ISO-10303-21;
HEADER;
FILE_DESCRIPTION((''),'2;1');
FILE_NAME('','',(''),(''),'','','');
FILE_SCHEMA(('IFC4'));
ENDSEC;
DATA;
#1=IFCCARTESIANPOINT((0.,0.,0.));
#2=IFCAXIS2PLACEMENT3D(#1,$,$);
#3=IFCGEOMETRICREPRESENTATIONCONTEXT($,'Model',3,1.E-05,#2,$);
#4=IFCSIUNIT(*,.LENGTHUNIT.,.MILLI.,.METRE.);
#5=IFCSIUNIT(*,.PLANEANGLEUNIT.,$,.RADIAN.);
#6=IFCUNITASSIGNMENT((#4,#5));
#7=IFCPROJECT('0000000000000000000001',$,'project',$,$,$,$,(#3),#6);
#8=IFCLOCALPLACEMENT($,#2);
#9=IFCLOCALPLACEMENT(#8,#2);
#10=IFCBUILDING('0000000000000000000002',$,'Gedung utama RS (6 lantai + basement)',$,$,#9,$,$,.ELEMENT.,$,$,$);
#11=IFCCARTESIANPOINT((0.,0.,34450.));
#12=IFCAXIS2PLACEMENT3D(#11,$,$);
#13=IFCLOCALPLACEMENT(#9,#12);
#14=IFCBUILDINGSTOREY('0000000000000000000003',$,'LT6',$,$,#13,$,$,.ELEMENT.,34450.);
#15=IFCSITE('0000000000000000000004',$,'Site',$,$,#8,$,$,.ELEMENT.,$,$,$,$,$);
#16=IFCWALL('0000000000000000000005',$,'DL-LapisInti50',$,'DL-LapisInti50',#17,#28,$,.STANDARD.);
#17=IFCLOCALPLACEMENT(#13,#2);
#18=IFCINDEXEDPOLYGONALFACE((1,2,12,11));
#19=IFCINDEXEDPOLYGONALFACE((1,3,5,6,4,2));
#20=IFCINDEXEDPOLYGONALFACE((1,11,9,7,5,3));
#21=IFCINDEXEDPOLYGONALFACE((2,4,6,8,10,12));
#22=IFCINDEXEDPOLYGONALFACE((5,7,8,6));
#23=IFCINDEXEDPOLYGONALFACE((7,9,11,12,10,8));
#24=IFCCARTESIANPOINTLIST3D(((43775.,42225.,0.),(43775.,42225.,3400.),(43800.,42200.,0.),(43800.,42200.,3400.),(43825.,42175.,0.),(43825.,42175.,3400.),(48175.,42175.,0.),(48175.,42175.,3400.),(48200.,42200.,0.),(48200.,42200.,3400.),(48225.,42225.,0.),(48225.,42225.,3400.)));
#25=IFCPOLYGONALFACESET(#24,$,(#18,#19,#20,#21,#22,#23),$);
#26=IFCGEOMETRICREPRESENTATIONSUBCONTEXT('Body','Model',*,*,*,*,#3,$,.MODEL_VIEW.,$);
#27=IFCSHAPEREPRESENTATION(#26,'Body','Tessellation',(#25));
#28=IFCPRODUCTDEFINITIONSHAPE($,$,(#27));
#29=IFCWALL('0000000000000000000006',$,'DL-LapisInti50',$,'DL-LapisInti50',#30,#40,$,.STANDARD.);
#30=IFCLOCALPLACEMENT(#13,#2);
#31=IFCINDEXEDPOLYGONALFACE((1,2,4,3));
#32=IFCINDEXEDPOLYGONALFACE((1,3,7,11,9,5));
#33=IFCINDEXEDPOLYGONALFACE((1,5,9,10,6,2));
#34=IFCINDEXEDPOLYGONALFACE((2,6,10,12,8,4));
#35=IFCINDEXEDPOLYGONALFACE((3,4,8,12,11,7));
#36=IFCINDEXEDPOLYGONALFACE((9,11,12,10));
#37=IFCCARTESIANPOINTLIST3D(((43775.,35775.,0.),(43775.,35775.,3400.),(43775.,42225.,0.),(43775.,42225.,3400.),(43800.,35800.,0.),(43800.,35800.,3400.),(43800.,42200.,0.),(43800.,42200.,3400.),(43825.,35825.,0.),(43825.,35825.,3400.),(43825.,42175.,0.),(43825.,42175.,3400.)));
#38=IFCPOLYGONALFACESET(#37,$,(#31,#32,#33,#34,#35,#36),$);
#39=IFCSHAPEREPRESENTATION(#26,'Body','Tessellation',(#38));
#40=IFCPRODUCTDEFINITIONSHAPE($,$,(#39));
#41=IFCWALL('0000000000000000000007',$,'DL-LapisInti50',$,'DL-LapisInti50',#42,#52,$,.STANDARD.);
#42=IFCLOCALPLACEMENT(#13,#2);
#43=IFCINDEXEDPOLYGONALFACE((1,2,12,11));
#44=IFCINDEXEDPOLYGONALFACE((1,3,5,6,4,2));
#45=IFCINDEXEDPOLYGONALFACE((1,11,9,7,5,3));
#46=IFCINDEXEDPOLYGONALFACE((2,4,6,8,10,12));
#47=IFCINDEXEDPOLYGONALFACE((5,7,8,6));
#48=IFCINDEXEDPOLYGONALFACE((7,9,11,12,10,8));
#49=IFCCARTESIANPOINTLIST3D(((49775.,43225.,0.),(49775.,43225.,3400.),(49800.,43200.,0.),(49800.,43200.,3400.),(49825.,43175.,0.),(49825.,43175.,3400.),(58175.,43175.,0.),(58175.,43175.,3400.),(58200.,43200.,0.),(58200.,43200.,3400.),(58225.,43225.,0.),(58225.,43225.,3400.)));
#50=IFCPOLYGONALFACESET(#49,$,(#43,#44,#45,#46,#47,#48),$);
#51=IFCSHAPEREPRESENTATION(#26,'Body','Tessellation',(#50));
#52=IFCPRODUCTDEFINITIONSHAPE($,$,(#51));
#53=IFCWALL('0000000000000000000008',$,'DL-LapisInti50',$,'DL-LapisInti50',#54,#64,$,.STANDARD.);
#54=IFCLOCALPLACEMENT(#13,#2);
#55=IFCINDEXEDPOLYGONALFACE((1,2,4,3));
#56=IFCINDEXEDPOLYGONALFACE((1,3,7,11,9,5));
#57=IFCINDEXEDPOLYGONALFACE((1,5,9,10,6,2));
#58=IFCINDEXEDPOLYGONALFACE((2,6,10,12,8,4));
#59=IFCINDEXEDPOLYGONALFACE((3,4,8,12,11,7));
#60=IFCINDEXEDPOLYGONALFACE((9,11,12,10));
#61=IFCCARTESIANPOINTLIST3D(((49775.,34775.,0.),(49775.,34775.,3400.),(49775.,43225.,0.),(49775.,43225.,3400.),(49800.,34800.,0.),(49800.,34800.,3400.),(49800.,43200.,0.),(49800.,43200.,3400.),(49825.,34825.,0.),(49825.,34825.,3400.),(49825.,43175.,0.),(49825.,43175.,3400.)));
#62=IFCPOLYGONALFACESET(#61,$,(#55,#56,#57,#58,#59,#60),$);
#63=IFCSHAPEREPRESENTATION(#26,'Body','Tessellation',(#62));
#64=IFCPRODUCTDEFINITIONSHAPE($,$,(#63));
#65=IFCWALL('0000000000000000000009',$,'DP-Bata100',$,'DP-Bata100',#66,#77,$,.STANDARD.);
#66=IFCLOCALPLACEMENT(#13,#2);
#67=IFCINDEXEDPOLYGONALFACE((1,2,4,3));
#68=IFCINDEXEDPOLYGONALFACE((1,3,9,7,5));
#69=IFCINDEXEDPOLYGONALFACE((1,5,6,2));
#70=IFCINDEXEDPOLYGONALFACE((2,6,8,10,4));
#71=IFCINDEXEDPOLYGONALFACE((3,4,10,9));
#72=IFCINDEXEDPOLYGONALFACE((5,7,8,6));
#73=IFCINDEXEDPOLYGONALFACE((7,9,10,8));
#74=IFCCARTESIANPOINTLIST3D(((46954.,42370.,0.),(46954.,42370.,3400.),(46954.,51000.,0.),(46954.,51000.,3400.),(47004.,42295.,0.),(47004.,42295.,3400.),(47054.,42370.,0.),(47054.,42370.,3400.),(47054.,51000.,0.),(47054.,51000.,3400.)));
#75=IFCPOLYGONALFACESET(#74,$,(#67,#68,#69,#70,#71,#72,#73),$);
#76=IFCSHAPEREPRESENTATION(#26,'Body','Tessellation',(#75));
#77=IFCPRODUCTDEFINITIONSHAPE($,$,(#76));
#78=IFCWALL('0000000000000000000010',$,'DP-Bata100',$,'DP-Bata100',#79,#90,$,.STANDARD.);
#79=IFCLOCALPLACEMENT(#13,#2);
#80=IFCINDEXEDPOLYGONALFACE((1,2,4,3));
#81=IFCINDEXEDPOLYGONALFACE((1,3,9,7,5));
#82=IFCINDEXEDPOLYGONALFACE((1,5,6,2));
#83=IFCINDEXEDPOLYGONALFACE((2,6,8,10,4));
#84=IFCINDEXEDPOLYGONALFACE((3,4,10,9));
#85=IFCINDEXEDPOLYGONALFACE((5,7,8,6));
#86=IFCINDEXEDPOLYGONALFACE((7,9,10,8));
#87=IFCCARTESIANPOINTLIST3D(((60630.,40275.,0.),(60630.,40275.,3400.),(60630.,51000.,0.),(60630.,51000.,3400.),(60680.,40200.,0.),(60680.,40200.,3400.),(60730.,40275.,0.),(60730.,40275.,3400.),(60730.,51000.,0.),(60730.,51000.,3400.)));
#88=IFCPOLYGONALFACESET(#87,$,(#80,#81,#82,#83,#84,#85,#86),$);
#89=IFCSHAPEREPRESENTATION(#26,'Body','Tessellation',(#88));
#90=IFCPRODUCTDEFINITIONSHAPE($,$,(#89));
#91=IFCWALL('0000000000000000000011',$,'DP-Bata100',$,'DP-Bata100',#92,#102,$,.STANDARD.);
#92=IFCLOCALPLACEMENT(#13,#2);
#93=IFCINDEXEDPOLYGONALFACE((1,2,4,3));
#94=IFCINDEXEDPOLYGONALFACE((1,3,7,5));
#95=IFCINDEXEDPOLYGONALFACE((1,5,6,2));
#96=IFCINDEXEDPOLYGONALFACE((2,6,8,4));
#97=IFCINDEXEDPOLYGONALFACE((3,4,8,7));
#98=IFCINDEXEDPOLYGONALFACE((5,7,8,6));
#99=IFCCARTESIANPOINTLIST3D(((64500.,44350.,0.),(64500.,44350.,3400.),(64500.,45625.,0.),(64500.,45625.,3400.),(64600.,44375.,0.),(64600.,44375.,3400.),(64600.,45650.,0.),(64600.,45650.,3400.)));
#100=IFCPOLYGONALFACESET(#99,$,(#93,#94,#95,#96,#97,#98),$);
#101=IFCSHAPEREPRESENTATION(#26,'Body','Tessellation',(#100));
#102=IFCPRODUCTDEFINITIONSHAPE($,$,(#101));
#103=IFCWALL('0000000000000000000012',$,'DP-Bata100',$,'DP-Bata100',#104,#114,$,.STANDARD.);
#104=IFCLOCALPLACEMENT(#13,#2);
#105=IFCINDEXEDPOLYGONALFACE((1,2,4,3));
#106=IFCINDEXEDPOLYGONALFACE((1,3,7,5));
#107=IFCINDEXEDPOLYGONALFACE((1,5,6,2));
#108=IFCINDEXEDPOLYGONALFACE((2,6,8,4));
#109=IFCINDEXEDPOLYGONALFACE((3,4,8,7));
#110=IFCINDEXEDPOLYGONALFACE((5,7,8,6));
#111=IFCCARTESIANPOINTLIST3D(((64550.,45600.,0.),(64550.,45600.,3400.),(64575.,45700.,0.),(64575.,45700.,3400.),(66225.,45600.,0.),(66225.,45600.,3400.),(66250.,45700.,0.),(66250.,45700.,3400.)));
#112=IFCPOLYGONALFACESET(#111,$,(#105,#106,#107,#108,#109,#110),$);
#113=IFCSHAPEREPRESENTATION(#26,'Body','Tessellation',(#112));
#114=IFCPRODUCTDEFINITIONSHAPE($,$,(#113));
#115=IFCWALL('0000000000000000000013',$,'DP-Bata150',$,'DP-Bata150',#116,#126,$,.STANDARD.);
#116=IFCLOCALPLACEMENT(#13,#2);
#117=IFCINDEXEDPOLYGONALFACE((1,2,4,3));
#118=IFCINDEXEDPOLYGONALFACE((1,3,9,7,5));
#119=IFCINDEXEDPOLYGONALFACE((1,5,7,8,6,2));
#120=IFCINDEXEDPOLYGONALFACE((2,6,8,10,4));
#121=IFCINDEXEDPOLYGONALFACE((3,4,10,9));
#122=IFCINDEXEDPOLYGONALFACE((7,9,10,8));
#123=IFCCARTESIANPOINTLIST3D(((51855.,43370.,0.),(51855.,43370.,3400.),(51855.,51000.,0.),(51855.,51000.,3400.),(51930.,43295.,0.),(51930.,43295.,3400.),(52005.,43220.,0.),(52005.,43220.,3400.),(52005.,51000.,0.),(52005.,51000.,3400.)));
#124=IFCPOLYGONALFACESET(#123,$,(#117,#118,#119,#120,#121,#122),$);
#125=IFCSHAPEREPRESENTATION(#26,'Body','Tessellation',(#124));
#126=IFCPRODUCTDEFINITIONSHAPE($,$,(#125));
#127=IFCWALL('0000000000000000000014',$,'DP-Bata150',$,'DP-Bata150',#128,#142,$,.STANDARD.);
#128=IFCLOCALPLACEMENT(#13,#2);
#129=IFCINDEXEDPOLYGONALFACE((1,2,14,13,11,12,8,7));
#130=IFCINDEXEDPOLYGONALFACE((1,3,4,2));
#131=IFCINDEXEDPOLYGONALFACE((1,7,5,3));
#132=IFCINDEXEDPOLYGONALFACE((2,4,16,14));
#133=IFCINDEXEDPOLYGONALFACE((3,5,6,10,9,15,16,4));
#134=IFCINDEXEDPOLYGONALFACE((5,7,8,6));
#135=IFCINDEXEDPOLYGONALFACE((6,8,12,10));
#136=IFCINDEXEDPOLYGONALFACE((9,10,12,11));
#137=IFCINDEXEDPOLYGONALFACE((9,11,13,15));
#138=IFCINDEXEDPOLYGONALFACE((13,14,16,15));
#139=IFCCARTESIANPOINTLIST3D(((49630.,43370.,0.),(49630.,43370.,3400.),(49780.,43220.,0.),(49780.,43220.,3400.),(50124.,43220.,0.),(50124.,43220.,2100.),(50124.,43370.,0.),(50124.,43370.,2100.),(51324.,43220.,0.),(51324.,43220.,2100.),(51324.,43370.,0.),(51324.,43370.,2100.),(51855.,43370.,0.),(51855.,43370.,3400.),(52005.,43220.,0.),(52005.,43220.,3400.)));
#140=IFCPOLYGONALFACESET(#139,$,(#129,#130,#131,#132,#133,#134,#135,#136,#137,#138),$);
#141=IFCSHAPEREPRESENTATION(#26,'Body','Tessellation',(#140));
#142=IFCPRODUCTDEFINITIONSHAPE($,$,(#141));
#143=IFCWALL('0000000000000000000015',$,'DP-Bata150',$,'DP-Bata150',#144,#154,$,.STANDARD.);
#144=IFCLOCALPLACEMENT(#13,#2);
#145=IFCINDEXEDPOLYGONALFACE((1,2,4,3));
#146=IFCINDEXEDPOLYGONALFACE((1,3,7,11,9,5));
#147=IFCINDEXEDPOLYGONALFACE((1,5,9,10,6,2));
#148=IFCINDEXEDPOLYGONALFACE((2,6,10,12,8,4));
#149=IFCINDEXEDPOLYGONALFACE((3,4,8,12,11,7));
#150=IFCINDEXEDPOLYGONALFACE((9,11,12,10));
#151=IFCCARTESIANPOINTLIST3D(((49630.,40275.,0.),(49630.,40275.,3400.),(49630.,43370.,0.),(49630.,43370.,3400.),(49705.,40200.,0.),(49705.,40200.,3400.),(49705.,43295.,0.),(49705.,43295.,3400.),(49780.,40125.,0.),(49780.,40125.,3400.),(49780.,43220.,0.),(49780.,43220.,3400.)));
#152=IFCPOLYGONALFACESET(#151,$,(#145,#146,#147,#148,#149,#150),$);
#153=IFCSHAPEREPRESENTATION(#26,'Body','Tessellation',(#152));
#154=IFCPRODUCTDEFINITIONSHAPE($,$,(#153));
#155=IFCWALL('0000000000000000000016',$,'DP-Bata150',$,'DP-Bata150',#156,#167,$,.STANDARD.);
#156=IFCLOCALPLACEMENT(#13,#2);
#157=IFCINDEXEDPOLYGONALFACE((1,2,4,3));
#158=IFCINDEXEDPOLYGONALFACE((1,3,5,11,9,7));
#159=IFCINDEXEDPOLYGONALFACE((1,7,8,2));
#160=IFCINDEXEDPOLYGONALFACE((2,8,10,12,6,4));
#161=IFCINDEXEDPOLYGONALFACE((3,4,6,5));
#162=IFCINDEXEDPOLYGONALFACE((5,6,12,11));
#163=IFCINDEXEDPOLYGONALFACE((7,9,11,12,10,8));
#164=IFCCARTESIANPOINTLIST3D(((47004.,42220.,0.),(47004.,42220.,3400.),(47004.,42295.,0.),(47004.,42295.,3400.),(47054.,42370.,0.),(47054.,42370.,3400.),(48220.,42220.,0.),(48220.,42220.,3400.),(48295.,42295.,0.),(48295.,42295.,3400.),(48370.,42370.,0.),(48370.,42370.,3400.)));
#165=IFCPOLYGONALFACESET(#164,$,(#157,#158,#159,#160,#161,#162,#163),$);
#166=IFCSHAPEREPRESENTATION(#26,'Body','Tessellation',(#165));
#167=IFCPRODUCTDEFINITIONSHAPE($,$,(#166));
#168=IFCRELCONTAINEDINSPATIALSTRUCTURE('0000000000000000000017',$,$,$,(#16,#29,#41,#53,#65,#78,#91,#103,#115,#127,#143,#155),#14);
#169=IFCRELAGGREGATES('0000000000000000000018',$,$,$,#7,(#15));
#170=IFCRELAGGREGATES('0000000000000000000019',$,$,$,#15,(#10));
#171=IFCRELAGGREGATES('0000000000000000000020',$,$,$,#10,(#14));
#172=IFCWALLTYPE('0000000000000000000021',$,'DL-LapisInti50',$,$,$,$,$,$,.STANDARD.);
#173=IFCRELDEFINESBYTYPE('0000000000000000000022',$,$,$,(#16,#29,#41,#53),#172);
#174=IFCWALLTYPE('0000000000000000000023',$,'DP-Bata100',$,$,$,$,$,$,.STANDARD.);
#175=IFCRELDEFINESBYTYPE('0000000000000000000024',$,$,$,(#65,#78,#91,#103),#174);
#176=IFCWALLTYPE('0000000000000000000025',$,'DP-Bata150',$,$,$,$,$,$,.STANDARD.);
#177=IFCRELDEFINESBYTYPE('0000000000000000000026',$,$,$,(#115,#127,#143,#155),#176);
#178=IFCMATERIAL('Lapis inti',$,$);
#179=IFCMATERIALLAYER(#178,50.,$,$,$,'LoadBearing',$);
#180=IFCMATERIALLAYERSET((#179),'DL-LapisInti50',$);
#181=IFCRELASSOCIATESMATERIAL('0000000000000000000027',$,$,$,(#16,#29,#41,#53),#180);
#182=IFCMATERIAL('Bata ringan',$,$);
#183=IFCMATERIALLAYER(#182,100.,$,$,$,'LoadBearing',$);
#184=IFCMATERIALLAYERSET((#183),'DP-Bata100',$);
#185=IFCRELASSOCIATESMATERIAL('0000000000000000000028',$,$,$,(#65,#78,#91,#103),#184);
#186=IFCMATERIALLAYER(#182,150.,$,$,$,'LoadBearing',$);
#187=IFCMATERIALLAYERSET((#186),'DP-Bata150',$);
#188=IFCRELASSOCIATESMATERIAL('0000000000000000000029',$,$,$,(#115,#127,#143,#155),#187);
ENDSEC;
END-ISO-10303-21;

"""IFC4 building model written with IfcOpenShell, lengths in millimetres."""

from ifc_helpers import new_model, si_unit, frame, frame_2d, origin, place, context, subcontext, project, spatial, polyline, rectangle, outline, extrude, material, layer, layer_set, layer_usage, type_object, element, save


model = new_model("IFC4")

# Units and contexts
model_context = context("Model", 3, precision=1e-05, world=origin())
body_context = subcontext(model_context, "Body", "Model", "MODEL_VIEW")
ifc_project = project(units=[si_unit("LENGTHUNIT", "METRE", prefix="MILLI"), si_unit("PLANEANGLEUNIT", "RADIAN")], contexts=[model_context])

# Site, building, storey
site_placement = place(None, origin())
site = spatial("IfcSite", under=ifc_project, at=site_placement, Name="Site", CompositionType="ELEMENT")
building_placement = place(site_placement, origin())
building = spatial("IfcBuilding", under=site, at=building_placement, Name="Gedung utama RS (6 lantai + basement)", CompositionType="ELEMENT")
storey_placement = place(building_placement, frame((0.0, 0.0, 34450.0)))
storey = spatial("IfcBuildingStorey", under=building, at=storey_placement, Name="LT6", CompositionType="ELEMENT", Elevation=34450.0)

# Walls
ifc_material_1 = material(Name="Lapis inti")
ifc_layer_1 = layer(ifc_material_1, 50.0, Category="LoadBearing")
ifc_layer_set_1 = layer_set([ifc_layer_1], Name="DL-LapisInti50")
ifc_layer_usage_1 = layer_usage(ifc_layer_set_1, "AXIS2", "NEGATIVE", 25.0)
wall_type_1 = type_object("IfcWallType", Name="DL-LapisInti50", PredefinedType="STANDARD")
wall_1_placement = place(storey_placement, frame((48200.0, 42200.0, 0.0), z_axis=(0.0, 0.0, 1.0), x_axis=(-1.0, 0.0, 0.0)))
element("IfcWall", 1, at=wall_1_placement, inside=storey, type_object=wall_type_1, material=ifc_layer_usage_1, Name="DL-LapisInti50", ObjectType="DL-LapisInti50", PredefinedType="STANDARD", context=body_context, shape_type="SweptSolid", body=[
    extrude(outline(polyline([(-25.0, -25.0), (0.0, 0.0), (25.0, 25.0), (4375.0, 25.0), (4400.0, 0.0), (4425.0, -25.0), (-25.0, -25.0)])), origin(), (0.0, 0.0, 1.0), 3400.0),
])
wall_2_placement = place(storey_placement, frame((43800.0, 42200.0, 0.0), z_axis=(0.0, 0.0, 1.0), x_axis=(0.0, -1.0, 0.0)))
element("IfcWall", 2, at=wall_2_placement, inside=storey, type_object=wall_type_1, material=ifc_layer_usage_1, Name="DL-LapisInti50", ObjectType="DL-LapisInti50", PredefinedType="STANDARD", context=body_context, shape_type="SweptSolid", body=[
    extrude(outline(polyline([(-25.0, -25.0), (0.0, 0.0), (25.0, 25.0), (6375.0, 25.0), (6400.0, 0.0), (6425.0, -25.0), (-25.0, -25.0)])), origin(), (0.0, 0.0, 1.0), 3400.0),
])
for number, where, z_axis, x_axis, name in (
    (3, (58200.0, 43200.0, 0.0), (0.0, 0.0, 1.0), (-1.0, 0.0, 0.0), "DL-LapisInti50"),
    (4, (49800.0, 43200.0, 0.0), (0.0, 0.0, 1.0), (0.0, -1.0, 0.0), "DL-LapisInti50"),
):
    element("IfcWall", number, at=place(storey_placement, frame(where, z_axis=z_axis, x_axis=x_axis)), inside=storey, type_object=wall_type_1, material=ifc_layer_usage_1, Name=name, ObjectType="DL-LapisInti50", PredefinedType="STANDARD", context=body_context, shape_type="SweptSolid", body=[
        extrude(outline(polyline([(-25.0, -25.0), (0.0, 0.0), (25.0, 25.0), (8375.0, 25.0), (8400.0, 0.0), (8425.0, -25.0), (-25.0, -25.0)])), origin(), (0.0, 0.0, 1.0), 3400.0),
    ])
ifc_material_2 = material(Name="Bata ringan")
ifc_layer_2 = layer(ifc_material_2, 100.0, Category="LoadBearing")
ifc_layer_set_2 = layer_set([ifc_layer_2], Name="DP-Bata100")
ifc_layer_usage_2 = layer_usage(ifc_layer_set_2, "AXIS2", "NEGATIVE", 50.0)
wall_type_2 = type_object("IfcWallType", Name="DP-Bata100", PredefinedType="STANDARD")
wall_3_placement = place(storey_placement, frame((47004.0, 51000.0, 0.0), z_axis=(0.0, 0.0, 1.0), x_axis=(0.0, -1.0, 0.0)))
element("IfcWall", 5, at=wall_3_placement, inside=storey, type_object=wall_type_2, material=ifc_layer_usage_2, Name="DP-Bata100", ObjectType="DP-Bata100", PredefinedType="STANDARD", context=body_context, shape_type="SweptSolid", body=[
    extrude(outline(polyline([(0.0, -50.0), (0.0, 50.0), (8630.0, 50.0), (8705.0, 0.0), (8630.0, -50.0), (0.0, -50.0)])), origin(), (0.0, 0.0, 1.0), 3400.0),
])
wall_4_placement = place(storey_placement, frame((60680.0, 51000.0, 0.0), z_axis=(0.0, 0.0, 1.0), x_axis=(0.0, -1.0, 0.0)))
element("IfcWall", 6, at=wall_4_placement, inside=storey, type_object=wall_type_2, material=ifc_layer_usage_2, Name="DP-Bata100", ObjectType="DP-Bata100", PredefinedType="STANDARD", context=body_context, shape_type="SweptSolid", body=[
    extrude(outline(polyline([(0.0, -50.0), (0.0, 50.0), (10725.0, 50.0), (10800.0, 0.0), (10725.0, -50.0), (0.0, -50.0)])), origin(), (0.0, 0.0, 1.0), 3400.0),
])
wall_5_placement = place(storey_placement, frame((64550.0, 44350.0, 0.0), z_axis=(0.0, 0.0, 1.0), x_axis=(0.0, 1.0, 0.0)))
element("IfcWall", 7, at=wall_5_placement, inside=storey, type_object=wall_type_2, material=ifc_layer_usage_2, Name="DP-Bata100", ObjectType="DP-Bata100", PredefinedType="STANDARD", context=body_context, shape_type="SweptSolid", body=[
    extrude(outline(polyline([(25.0, -50.0), (0.0, 50.0), (1275.0, 50.0), (1300.0, -50.0), (25.0, -50.0)])), origin(), (0.0, 0.0, 1.0), 3400.0),
])
wall_6_placement = place(storey_placement, frame((64550.0, 45650.0, 0.0), z_axis=(0.0, 0.0, 1.0), x_axis=(1.0, 0.0, 0.0)))
element("IfcWall", 8, at=wall_6_placement, inside=storey, type_object=wall_type_2, material=ifc_layer_usage_2, Name="DP-Bata100", ObjectType="DP-Bata100", PredefinedType="STANDARD", context=body_context, shape_type="SweptSolid", body=[
    extrude(outline(polyline([(0.0, -50.0), (25.0, 50.0), (1700.0, 50.0), (1675.0, -50.0), (0.0, -50.0)])), origin(), (0.0, 0.0, 1.0), 3400.0),
])
ifc_layer_3 = layer(ifc_material_2, 150.0, Category="LoadBearing")
ifc_layer_set_3 = layer_set([ifc_layer_3], Name="DP-Bata150")
ifc_layer_usage_3 = layer_usage(ifc_layer_set_3, "AXIS2", "NEGATIVE", 75.0)
wall_type_3 = type_object("IfcWallType", Name="DP-Bata150", PredefinedType="STANDARD")
wall_7_placement = place(storey_placement, frame((51930.0, 51000.0, 0.0), z_axis=(0.0, 0.0, 1.0), x_axis=(0.0, -1.0, 0.0)))
element("IfcWall", 9, at=wall_7_placement, inside=storey, type_object=wall_type_3, material=ifc_layer_usage_3, Name="DP-Bata150", ObjectType="DP-Bata150", PredefinedType="STANDARD", context=body_context, shape_type="SweptSolid", body=[
    extrude(outline(polyline([(0.0, -75.0), (0.0, 75.0), (7780.0, 75.0), (7705.0, 0.0), (7630.0, -75.0), (0.0, -75.0)])), origin(), (0.0, 0.0, 1.0), 3400.0),
])

# Wall, opening
wall_8_placement = place(storey_placement, frame((51930.0, 43295.0, 0.0), z_axis=(0.0, 0.0, 1.0), x_axis=(-1.0, 0.0, 0.0)))
wall_8 = element("IfcWall", 10, at=wall_8_placement, inside=storey, type_object=wall_type_3, material=ifc_layer_usage_3, Name="DP-Bata150", ObjectType="DP-Bata150", PredefinedType="STANDARD", context=body_context, shape_type="SweptSolid", body=[
    extrude(outline(polyline([(75.0, -75.0), (0.0, 0.0), (-75.0, 75.0), (2150.0, 75.0), (2225.0, 0.0), (2300.0, -75.0), (75.0, -75.0)])), origin(), (0.0, 0.0, 1.0), 3400.0),
])
opening_1_placement = place(wall_8_placement, frame((606.0, 0.0, 0.0), z_axis=(0.0, 0.0, 1.0), x_axis=(1.0, 0.0, 0.0)))
element("IfcOpeningElement", 11, at=opening_1_placement, cuts=wall_8, PredefinedType="OPENING", context=body_context, shape_type="SweptSolid", body=[
    extrude(rectangle(XDim=1200.0, YDim=170.0, at=frame_2d((600.0, 0.0))), origin(), (0.0, 0.0, 1.0), 2100.0),
])

# Walls
wall_9_placement = place(storey_placement, frame((49705.0, 43295.0, 0.0), z_axis=(0.0, 0.0, 1.0), x_axis=(0.0, -1.0, 0.0)))
element("IfcWall", 12, at=wall_9_placement, inside=storey, type_object=wall_type_3, material=ifc_layer_usage_3, Name="DP-Bata150", ObjectType="DP-Bata150", PredefinedType="STANDARD", context=body_context, shape_type="SweptSolid", body=[
    extrude(outline(polyline([(-75.0, -75.0), (0.0, 0.0), (75.0, 75.0), (3170.0, 75.0), (3095.0, 0.0), (3020.0, -75.0), (-75.0, -75.0)])), origin(), (0.0, 0.0, 1.0), 3400.0),
])
wall_10_placement = place(storey_placement, frame((48295.0, 42295.0, 0.0), z_axis=(0.0, 0.0, 1.0), x_axis=(-1.0, 0.0, 0.0)))
element("IfcWall", 13, at=wall_10_placement, inside=storey, type_object=wall_type_3, material=ifc_layer_usage_3, Name="DP-Bata150", ObjectType="DP-Bata150", PredefinedType="STANDARD", context=body_context, shape_type="SweptSolid", body=[
    extrude(outline(polyline([(-75.0, -75.0), (0.0, 0.0), (75.0, 75.0), (1291.0, 75.0), (1291.0, 0.0), (1241.0, -75.0), (-75.0, -75.0)])), origin(), (0.0, 0.0, 1.0), 3400.0),
])

save(model, "model.ifc")
